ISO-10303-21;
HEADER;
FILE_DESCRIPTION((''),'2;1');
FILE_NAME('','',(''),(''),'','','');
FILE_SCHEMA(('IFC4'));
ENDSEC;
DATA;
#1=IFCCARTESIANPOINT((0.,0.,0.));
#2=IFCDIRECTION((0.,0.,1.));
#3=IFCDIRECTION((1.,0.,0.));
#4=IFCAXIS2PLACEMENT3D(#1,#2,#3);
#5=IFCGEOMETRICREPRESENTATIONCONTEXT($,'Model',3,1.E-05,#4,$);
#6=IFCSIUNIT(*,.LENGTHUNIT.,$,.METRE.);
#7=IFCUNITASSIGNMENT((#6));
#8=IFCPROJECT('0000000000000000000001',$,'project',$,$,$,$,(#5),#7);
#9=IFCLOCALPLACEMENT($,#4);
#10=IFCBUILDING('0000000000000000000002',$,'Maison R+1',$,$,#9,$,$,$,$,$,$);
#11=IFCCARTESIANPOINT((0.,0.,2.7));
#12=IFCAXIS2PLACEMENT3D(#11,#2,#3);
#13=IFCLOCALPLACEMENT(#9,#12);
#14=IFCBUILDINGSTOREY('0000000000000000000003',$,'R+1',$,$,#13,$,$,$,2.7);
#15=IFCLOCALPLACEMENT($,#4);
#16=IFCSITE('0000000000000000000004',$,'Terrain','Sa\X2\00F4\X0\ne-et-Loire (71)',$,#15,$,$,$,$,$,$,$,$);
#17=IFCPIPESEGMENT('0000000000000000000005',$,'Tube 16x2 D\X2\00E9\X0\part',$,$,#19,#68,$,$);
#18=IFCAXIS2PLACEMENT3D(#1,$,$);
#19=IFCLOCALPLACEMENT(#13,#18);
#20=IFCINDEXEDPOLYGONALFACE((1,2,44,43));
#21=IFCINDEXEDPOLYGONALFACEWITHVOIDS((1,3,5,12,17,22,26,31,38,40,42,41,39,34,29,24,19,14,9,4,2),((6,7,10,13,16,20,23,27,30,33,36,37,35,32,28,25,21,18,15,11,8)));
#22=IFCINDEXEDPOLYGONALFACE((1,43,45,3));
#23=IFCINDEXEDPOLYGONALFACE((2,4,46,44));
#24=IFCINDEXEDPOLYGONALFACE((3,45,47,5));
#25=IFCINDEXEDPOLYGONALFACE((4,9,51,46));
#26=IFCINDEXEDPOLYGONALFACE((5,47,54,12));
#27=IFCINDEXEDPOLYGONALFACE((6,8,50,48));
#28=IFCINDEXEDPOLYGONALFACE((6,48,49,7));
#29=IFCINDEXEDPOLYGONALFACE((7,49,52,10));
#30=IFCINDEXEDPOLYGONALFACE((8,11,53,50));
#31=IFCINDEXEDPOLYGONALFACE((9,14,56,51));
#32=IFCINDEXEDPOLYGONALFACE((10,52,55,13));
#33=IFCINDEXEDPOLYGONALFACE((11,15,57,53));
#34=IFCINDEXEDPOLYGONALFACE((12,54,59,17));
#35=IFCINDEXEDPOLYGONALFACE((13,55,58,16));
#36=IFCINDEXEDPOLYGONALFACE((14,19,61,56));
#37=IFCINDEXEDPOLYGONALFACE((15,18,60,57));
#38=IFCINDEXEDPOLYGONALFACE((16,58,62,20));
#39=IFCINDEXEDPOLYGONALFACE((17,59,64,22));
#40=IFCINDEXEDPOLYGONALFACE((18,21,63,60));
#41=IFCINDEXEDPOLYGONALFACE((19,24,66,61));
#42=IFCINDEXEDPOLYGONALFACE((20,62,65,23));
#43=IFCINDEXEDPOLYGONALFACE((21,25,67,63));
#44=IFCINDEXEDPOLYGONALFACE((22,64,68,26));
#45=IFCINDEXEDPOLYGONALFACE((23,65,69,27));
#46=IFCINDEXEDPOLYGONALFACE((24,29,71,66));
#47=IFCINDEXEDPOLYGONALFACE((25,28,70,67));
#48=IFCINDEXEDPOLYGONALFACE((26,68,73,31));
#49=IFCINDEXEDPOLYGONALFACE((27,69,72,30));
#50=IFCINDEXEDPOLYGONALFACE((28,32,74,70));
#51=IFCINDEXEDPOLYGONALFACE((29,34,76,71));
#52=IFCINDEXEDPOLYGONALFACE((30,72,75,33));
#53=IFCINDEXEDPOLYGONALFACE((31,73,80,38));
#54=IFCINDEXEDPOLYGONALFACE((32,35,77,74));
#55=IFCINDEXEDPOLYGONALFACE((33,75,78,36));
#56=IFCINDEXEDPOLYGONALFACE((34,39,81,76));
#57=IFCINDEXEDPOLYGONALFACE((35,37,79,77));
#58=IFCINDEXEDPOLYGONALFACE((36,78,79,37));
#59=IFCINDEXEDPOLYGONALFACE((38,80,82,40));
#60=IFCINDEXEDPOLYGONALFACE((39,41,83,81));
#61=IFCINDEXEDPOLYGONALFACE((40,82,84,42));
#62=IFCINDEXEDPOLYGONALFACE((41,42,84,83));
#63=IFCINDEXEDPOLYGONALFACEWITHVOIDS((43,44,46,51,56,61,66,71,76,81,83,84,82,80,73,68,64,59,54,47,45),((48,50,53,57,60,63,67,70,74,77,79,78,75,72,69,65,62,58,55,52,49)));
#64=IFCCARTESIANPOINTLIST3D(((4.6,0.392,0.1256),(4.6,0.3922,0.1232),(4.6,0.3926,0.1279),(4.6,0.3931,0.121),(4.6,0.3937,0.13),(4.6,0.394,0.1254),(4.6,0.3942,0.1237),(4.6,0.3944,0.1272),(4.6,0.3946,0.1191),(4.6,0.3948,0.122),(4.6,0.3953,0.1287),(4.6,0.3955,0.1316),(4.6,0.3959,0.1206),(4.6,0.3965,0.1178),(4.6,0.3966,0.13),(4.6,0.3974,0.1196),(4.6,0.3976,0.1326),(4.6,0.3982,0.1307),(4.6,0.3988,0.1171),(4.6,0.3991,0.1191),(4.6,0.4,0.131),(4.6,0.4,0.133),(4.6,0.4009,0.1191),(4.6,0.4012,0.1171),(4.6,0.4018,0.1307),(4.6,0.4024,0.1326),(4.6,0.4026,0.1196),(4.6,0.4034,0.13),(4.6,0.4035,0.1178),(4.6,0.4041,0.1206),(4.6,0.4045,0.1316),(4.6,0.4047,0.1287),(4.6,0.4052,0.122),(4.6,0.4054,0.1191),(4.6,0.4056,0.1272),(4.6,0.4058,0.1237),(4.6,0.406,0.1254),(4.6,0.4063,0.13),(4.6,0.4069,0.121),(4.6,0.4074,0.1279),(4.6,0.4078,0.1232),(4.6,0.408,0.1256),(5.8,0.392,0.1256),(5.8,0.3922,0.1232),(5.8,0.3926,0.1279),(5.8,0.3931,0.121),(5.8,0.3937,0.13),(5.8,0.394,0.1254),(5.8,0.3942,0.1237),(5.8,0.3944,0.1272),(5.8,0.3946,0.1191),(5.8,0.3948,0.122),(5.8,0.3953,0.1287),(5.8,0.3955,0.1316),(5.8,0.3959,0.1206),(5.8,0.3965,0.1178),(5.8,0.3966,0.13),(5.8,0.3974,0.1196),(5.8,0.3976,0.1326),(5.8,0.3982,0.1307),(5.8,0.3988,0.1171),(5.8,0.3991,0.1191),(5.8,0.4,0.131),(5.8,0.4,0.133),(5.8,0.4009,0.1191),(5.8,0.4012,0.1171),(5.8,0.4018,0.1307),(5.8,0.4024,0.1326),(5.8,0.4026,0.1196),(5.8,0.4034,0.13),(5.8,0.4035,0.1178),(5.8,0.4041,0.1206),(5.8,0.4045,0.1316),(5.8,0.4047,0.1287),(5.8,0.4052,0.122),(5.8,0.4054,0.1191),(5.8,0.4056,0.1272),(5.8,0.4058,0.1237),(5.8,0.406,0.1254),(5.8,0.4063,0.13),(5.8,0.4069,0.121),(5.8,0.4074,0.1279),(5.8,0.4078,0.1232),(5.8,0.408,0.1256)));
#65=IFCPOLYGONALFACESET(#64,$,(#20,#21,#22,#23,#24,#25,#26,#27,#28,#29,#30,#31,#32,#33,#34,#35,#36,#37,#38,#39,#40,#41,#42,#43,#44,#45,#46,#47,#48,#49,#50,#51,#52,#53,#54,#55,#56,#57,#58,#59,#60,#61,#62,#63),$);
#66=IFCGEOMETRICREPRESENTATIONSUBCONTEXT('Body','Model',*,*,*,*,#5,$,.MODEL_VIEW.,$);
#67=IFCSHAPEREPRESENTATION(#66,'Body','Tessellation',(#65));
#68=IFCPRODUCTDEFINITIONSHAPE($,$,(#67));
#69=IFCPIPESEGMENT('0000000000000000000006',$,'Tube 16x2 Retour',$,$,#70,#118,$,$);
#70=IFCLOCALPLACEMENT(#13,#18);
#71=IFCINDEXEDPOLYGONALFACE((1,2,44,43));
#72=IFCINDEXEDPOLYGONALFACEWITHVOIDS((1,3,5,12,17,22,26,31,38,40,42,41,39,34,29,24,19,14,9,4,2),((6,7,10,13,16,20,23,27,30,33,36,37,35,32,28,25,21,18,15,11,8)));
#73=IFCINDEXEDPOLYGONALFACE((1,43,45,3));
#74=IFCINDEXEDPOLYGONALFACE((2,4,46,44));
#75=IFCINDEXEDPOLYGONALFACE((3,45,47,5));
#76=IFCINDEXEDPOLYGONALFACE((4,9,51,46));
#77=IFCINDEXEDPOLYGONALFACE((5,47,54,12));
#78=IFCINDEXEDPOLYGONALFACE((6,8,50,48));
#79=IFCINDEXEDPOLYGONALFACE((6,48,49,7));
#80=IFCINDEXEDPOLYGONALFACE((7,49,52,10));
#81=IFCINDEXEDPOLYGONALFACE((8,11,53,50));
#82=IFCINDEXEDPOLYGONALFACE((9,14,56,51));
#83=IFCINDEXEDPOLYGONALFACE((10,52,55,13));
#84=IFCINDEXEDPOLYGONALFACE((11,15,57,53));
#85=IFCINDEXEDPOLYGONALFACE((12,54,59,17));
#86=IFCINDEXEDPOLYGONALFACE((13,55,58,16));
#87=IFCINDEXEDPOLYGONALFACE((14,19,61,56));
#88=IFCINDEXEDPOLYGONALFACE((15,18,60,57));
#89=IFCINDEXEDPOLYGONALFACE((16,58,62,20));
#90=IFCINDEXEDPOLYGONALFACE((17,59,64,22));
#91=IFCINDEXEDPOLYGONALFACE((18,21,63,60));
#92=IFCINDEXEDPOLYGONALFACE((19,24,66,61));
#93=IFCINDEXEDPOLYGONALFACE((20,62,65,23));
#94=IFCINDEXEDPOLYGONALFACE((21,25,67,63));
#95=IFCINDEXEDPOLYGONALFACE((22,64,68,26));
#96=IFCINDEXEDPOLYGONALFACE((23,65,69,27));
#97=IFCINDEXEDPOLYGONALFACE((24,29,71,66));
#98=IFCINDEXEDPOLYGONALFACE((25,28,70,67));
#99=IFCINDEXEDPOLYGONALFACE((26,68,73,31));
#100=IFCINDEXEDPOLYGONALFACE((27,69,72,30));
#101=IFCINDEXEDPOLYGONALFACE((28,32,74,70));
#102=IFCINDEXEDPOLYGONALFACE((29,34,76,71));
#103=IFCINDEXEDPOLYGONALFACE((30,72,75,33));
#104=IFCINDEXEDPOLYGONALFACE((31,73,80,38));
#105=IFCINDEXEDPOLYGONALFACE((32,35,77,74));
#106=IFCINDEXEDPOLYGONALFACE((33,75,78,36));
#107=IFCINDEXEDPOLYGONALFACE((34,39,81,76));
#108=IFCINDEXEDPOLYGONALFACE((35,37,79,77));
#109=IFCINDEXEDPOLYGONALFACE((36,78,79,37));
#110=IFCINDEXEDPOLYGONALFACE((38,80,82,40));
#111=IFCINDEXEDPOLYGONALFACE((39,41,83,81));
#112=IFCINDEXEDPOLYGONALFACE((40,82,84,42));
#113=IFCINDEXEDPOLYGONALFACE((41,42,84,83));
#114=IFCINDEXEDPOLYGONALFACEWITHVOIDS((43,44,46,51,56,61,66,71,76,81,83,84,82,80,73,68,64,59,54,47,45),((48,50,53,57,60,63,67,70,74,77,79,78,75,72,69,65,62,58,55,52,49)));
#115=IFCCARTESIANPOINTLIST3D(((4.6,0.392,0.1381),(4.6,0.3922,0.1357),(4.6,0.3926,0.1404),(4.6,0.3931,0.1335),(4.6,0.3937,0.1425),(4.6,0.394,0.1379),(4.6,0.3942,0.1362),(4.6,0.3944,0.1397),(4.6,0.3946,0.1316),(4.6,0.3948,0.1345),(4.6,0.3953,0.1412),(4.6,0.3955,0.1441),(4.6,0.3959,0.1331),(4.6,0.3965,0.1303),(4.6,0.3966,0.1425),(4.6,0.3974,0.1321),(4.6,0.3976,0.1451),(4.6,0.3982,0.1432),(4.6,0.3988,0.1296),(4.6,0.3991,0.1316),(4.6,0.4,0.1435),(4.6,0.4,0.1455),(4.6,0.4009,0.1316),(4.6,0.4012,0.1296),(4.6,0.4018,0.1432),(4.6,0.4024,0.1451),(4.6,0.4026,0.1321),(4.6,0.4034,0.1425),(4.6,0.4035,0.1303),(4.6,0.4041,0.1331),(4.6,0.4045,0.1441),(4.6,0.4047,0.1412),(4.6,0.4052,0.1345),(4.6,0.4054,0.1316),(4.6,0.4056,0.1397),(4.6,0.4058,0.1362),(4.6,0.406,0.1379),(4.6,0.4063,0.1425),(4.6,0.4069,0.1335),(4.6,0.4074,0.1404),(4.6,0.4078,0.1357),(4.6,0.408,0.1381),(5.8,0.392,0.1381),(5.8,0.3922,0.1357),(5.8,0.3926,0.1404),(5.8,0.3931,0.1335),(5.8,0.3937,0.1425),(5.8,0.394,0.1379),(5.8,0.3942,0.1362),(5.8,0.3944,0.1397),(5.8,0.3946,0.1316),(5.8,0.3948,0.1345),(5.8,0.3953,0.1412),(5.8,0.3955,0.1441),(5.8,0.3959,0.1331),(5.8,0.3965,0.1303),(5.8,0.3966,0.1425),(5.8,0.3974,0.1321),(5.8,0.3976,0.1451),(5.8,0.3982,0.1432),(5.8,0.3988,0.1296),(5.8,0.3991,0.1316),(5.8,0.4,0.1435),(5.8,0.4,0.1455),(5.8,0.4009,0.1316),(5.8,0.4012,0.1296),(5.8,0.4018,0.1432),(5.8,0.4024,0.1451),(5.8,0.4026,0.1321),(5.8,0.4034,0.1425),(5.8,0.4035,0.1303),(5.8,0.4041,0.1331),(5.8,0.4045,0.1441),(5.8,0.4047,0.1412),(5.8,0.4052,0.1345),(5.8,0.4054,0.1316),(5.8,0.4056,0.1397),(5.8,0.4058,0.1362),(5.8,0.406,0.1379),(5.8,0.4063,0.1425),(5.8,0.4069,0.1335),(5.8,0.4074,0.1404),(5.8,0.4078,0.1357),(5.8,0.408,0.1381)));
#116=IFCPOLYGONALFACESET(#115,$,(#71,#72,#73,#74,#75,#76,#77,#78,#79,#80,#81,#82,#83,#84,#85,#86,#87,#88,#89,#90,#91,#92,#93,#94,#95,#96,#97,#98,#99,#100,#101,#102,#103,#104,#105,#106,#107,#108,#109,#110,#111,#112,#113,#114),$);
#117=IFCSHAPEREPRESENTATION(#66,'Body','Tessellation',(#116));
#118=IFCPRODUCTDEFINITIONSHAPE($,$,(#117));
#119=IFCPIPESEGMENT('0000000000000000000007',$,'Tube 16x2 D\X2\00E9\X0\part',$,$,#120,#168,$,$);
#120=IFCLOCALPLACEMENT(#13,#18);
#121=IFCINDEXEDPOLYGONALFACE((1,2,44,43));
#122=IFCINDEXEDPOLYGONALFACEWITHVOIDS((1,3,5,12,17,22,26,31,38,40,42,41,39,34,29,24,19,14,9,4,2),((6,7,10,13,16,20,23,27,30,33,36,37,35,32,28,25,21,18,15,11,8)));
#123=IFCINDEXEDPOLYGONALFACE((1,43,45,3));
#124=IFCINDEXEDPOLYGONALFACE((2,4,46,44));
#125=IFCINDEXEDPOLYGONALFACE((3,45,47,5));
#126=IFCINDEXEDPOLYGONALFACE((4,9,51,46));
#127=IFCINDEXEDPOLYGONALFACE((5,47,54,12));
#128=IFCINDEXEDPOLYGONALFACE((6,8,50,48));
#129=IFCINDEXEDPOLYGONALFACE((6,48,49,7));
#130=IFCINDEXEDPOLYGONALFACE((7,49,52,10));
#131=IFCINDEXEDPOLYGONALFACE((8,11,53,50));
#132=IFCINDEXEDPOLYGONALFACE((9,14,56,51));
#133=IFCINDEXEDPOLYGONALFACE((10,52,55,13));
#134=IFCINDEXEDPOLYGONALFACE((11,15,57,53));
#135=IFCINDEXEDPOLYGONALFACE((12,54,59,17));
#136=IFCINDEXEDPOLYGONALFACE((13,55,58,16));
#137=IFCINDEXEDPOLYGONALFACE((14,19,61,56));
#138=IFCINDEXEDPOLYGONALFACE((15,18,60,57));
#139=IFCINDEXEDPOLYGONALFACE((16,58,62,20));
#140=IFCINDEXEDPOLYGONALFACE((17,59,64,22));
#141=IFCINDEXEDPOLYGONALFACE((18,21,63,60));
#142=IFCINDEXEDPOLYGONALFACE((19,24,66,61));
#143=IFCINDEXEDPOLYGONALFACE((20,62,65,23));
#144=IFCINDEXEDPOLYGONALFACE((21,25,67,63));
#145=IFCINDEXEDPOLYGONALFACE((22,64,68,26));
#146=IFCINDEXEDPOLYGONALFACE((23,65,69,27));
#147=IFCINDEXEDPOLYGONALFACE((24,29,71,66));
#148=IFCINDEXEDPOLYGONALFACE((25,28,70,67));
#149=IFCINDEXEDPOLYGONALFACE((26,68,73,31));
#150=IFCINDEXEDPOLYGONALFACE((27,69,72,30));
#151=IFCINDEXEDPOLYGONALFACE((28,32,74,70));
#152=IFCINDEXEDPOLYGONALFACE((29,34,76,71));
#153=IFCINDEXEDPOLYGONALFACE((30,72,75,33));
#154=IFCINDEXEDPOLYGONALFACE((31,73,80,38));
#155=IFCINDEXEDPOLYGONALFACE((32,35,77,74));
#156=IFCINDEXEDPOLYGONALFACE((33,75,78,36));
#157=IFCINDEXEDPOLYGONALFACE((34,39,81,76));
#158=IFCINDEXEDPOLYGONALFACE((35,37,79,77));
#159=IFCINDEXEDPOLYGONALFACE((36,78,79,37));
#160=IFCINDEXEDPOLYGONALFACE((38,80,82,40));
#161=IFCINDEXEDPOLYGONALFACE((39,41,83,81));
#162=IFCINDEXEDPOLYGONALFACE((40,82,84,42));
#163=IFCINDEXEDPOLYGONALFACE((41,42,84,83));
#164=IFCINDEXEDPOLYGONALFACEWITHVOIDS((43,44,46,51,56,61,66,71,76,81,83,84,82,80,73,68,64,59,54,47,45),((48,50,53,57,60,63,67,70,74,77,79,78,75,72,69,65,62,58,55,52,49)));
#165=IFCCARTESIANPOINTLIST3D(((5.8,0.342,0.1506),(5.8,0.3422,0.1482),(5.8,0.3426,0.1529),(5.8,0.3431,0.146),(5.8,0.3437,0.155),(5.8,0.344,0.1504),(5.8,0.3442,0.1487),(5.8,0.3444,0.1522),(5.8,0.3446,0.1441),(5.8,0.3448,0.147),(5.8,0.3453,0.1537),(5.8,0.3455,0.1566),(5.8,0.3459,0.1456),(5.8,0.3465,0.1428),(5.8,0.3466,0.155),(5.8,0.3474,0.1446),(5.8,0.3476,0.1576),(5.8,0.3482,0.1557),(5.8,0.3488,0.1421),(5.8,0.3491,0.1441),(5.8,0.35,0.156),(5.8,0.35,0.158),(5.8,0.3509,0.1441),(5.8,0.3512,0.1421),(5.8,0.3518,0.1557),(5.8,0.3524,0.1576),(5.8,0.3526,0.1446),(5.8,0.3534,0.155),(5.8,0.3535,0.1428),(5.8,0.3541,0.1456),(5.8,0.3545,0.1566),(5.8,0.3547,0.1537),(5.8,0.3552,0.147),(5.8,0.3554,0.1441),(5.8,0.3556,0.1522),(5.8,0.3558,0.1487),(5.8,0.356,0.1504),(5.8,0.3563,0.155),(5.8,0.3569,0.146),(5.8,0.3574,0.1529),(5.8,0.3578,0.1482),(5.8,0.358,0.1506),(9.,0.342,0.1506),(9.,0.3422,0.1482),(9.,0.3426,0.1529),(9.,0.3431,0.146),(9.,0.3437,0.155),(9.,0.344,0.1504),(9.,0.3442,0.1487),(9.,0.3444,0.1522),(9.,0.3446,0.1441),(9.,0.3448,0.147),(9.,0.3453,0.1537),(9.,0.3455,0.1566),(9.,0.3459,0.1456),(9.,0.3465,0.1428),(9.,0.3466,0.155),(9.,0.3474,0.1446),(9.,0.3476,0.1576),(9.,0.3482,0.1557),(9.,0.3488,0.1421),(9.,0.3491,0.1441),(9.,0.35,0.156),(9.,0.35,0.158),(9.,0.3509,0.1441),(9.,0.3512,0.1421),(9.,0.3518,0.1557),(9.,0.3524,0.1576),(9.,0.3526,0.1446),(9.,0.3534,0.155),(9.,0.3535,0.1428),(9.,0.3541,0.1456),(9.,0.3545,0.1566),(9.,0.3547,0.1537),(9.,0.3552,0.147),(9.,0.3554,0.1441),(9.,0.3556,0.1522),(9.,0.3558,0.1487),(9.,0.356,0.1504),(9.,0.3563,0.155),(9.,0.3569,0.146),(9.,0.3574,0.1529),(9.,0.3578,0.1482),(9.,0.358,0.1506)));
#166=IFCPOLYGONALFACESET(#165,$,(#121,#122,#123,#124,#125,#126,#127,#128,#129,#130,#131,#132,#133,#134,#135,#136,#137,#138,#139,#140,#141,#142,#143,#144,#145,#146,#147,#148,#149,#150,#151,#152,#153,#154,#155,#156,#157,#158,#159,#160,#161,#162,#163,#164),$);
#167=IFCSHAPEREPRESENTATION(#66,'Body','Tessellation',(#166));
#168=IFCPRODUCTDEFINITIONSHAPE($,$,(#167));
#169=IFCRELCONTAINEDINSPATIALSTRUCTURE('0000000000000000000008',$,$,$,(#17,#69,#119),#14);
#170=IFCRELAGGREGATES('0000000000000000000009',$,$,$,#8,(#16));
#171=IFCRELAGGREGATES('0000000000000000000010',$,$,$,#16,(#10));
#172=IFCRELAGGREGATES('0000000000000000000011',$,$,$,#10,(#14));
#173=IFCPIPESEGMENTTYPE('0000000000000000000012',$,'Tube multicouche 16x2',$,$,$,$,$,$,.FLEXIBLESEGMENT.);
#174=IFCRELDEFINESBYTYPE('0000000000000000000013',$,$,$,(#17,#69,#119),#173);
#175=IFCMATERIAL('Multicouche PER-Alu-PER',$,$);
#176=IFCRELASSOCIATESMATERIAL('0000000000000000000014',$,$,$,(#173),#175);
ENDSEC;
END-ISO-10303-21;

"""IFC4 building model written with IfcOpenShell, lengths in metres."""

from ifc_helpers import new_model, si_unit, frame, origin_with_axes, place, context, subcontext, project, spatial, hollow_circle, extrude, material, type_object, element, save


model = new_model("IFC4")

# Units and contexts
model_context = context("Model", 3, precision=1e-05, world=origin_with_axes())
body_context = subcontext(model_context, "Body", "Model", "MODEL_VIEW")
ifc_project = project(units=[si_unit("LENGTHUNIT", "METRE")], contexts=[model_context])

# Site, building, storey
site_placement = place(None, origin_with_axes())
site = spatial("IfcSite", under=ifc_project, at=site_placement, Name="Terrain", Description="Saône-et-Loire (71)")
building_placement = place(None, origin_with_axes())
building = spatial("IfcBuilding", under=site, at=building_placement, Name="Maison R+1")
storey_placement = place(building_placement, frame((0.0, 0.0, 2.7), z_axis=(0.0, 0.0, 1.0), x_axis=(1.0, 0.0, 0.0)))
storey = spatial("IfcBuildingStorey", under=building, at=storey_placement, Name="R+1", Elevation=2.7)

# Pipe segments
ifc_material_1 = material(Name="Multicouche PER-Alu-PER")
pipe_segment_type = type_object("IfcPipeSegmentType", Name="Tube multicouche 16x2", PredefinedType="FLEXIBLESEGMENT", material=ifc_material_1)
for number, where, z_axis, x_axis, name in (
    (1, (4.6, 0.4, 0.125), (1.0, 0.0, 0.0), (0.0, 0.0, 1.0), "Tube 16x2 Départ"),
    (2, (4.6, 0.4, 0.1375), (1.0, 0.0, 0.0), (0.0, 0.0, 1.0), "Tube 16x2 Retour"),
):
    element("IfcPipeSegment", number, at=place(storey_placement, frame(where, z_axis=z_axis, x_axis=x_axis)), inside=storey, type_object=pipe_segment_type, Name=name, context=body_context, shape_type="SweptSolid", body=[
        extrude(hollow_circle(Radius=0.008, WallThickness=0.002), origin_with_axes(), (0.0, 0.0, 1.0), 1.2),
    ])
pipe_segment_1_placement = place(storey_placement, frame((5.8, 0.35, 0.15), z_axis=(1.0, 0.0, 0.0), x_axis=(0.0, 0.0, 1.0)))
element("IfcPipeSegment", 3, at=pipe_segment_1_placement, inside=storey, type_object=pipe_segment_type, Name="Tube 16x2 Départ", context=body_context, shape_type="SweptSolid", body=[
    extrude(hollow_circle(Radius=0.008, WallThickness=0.002), origin_with_axes(), (0.0, 0.0, 1.0), 3.2),
])

save(model, "model.ifc")
